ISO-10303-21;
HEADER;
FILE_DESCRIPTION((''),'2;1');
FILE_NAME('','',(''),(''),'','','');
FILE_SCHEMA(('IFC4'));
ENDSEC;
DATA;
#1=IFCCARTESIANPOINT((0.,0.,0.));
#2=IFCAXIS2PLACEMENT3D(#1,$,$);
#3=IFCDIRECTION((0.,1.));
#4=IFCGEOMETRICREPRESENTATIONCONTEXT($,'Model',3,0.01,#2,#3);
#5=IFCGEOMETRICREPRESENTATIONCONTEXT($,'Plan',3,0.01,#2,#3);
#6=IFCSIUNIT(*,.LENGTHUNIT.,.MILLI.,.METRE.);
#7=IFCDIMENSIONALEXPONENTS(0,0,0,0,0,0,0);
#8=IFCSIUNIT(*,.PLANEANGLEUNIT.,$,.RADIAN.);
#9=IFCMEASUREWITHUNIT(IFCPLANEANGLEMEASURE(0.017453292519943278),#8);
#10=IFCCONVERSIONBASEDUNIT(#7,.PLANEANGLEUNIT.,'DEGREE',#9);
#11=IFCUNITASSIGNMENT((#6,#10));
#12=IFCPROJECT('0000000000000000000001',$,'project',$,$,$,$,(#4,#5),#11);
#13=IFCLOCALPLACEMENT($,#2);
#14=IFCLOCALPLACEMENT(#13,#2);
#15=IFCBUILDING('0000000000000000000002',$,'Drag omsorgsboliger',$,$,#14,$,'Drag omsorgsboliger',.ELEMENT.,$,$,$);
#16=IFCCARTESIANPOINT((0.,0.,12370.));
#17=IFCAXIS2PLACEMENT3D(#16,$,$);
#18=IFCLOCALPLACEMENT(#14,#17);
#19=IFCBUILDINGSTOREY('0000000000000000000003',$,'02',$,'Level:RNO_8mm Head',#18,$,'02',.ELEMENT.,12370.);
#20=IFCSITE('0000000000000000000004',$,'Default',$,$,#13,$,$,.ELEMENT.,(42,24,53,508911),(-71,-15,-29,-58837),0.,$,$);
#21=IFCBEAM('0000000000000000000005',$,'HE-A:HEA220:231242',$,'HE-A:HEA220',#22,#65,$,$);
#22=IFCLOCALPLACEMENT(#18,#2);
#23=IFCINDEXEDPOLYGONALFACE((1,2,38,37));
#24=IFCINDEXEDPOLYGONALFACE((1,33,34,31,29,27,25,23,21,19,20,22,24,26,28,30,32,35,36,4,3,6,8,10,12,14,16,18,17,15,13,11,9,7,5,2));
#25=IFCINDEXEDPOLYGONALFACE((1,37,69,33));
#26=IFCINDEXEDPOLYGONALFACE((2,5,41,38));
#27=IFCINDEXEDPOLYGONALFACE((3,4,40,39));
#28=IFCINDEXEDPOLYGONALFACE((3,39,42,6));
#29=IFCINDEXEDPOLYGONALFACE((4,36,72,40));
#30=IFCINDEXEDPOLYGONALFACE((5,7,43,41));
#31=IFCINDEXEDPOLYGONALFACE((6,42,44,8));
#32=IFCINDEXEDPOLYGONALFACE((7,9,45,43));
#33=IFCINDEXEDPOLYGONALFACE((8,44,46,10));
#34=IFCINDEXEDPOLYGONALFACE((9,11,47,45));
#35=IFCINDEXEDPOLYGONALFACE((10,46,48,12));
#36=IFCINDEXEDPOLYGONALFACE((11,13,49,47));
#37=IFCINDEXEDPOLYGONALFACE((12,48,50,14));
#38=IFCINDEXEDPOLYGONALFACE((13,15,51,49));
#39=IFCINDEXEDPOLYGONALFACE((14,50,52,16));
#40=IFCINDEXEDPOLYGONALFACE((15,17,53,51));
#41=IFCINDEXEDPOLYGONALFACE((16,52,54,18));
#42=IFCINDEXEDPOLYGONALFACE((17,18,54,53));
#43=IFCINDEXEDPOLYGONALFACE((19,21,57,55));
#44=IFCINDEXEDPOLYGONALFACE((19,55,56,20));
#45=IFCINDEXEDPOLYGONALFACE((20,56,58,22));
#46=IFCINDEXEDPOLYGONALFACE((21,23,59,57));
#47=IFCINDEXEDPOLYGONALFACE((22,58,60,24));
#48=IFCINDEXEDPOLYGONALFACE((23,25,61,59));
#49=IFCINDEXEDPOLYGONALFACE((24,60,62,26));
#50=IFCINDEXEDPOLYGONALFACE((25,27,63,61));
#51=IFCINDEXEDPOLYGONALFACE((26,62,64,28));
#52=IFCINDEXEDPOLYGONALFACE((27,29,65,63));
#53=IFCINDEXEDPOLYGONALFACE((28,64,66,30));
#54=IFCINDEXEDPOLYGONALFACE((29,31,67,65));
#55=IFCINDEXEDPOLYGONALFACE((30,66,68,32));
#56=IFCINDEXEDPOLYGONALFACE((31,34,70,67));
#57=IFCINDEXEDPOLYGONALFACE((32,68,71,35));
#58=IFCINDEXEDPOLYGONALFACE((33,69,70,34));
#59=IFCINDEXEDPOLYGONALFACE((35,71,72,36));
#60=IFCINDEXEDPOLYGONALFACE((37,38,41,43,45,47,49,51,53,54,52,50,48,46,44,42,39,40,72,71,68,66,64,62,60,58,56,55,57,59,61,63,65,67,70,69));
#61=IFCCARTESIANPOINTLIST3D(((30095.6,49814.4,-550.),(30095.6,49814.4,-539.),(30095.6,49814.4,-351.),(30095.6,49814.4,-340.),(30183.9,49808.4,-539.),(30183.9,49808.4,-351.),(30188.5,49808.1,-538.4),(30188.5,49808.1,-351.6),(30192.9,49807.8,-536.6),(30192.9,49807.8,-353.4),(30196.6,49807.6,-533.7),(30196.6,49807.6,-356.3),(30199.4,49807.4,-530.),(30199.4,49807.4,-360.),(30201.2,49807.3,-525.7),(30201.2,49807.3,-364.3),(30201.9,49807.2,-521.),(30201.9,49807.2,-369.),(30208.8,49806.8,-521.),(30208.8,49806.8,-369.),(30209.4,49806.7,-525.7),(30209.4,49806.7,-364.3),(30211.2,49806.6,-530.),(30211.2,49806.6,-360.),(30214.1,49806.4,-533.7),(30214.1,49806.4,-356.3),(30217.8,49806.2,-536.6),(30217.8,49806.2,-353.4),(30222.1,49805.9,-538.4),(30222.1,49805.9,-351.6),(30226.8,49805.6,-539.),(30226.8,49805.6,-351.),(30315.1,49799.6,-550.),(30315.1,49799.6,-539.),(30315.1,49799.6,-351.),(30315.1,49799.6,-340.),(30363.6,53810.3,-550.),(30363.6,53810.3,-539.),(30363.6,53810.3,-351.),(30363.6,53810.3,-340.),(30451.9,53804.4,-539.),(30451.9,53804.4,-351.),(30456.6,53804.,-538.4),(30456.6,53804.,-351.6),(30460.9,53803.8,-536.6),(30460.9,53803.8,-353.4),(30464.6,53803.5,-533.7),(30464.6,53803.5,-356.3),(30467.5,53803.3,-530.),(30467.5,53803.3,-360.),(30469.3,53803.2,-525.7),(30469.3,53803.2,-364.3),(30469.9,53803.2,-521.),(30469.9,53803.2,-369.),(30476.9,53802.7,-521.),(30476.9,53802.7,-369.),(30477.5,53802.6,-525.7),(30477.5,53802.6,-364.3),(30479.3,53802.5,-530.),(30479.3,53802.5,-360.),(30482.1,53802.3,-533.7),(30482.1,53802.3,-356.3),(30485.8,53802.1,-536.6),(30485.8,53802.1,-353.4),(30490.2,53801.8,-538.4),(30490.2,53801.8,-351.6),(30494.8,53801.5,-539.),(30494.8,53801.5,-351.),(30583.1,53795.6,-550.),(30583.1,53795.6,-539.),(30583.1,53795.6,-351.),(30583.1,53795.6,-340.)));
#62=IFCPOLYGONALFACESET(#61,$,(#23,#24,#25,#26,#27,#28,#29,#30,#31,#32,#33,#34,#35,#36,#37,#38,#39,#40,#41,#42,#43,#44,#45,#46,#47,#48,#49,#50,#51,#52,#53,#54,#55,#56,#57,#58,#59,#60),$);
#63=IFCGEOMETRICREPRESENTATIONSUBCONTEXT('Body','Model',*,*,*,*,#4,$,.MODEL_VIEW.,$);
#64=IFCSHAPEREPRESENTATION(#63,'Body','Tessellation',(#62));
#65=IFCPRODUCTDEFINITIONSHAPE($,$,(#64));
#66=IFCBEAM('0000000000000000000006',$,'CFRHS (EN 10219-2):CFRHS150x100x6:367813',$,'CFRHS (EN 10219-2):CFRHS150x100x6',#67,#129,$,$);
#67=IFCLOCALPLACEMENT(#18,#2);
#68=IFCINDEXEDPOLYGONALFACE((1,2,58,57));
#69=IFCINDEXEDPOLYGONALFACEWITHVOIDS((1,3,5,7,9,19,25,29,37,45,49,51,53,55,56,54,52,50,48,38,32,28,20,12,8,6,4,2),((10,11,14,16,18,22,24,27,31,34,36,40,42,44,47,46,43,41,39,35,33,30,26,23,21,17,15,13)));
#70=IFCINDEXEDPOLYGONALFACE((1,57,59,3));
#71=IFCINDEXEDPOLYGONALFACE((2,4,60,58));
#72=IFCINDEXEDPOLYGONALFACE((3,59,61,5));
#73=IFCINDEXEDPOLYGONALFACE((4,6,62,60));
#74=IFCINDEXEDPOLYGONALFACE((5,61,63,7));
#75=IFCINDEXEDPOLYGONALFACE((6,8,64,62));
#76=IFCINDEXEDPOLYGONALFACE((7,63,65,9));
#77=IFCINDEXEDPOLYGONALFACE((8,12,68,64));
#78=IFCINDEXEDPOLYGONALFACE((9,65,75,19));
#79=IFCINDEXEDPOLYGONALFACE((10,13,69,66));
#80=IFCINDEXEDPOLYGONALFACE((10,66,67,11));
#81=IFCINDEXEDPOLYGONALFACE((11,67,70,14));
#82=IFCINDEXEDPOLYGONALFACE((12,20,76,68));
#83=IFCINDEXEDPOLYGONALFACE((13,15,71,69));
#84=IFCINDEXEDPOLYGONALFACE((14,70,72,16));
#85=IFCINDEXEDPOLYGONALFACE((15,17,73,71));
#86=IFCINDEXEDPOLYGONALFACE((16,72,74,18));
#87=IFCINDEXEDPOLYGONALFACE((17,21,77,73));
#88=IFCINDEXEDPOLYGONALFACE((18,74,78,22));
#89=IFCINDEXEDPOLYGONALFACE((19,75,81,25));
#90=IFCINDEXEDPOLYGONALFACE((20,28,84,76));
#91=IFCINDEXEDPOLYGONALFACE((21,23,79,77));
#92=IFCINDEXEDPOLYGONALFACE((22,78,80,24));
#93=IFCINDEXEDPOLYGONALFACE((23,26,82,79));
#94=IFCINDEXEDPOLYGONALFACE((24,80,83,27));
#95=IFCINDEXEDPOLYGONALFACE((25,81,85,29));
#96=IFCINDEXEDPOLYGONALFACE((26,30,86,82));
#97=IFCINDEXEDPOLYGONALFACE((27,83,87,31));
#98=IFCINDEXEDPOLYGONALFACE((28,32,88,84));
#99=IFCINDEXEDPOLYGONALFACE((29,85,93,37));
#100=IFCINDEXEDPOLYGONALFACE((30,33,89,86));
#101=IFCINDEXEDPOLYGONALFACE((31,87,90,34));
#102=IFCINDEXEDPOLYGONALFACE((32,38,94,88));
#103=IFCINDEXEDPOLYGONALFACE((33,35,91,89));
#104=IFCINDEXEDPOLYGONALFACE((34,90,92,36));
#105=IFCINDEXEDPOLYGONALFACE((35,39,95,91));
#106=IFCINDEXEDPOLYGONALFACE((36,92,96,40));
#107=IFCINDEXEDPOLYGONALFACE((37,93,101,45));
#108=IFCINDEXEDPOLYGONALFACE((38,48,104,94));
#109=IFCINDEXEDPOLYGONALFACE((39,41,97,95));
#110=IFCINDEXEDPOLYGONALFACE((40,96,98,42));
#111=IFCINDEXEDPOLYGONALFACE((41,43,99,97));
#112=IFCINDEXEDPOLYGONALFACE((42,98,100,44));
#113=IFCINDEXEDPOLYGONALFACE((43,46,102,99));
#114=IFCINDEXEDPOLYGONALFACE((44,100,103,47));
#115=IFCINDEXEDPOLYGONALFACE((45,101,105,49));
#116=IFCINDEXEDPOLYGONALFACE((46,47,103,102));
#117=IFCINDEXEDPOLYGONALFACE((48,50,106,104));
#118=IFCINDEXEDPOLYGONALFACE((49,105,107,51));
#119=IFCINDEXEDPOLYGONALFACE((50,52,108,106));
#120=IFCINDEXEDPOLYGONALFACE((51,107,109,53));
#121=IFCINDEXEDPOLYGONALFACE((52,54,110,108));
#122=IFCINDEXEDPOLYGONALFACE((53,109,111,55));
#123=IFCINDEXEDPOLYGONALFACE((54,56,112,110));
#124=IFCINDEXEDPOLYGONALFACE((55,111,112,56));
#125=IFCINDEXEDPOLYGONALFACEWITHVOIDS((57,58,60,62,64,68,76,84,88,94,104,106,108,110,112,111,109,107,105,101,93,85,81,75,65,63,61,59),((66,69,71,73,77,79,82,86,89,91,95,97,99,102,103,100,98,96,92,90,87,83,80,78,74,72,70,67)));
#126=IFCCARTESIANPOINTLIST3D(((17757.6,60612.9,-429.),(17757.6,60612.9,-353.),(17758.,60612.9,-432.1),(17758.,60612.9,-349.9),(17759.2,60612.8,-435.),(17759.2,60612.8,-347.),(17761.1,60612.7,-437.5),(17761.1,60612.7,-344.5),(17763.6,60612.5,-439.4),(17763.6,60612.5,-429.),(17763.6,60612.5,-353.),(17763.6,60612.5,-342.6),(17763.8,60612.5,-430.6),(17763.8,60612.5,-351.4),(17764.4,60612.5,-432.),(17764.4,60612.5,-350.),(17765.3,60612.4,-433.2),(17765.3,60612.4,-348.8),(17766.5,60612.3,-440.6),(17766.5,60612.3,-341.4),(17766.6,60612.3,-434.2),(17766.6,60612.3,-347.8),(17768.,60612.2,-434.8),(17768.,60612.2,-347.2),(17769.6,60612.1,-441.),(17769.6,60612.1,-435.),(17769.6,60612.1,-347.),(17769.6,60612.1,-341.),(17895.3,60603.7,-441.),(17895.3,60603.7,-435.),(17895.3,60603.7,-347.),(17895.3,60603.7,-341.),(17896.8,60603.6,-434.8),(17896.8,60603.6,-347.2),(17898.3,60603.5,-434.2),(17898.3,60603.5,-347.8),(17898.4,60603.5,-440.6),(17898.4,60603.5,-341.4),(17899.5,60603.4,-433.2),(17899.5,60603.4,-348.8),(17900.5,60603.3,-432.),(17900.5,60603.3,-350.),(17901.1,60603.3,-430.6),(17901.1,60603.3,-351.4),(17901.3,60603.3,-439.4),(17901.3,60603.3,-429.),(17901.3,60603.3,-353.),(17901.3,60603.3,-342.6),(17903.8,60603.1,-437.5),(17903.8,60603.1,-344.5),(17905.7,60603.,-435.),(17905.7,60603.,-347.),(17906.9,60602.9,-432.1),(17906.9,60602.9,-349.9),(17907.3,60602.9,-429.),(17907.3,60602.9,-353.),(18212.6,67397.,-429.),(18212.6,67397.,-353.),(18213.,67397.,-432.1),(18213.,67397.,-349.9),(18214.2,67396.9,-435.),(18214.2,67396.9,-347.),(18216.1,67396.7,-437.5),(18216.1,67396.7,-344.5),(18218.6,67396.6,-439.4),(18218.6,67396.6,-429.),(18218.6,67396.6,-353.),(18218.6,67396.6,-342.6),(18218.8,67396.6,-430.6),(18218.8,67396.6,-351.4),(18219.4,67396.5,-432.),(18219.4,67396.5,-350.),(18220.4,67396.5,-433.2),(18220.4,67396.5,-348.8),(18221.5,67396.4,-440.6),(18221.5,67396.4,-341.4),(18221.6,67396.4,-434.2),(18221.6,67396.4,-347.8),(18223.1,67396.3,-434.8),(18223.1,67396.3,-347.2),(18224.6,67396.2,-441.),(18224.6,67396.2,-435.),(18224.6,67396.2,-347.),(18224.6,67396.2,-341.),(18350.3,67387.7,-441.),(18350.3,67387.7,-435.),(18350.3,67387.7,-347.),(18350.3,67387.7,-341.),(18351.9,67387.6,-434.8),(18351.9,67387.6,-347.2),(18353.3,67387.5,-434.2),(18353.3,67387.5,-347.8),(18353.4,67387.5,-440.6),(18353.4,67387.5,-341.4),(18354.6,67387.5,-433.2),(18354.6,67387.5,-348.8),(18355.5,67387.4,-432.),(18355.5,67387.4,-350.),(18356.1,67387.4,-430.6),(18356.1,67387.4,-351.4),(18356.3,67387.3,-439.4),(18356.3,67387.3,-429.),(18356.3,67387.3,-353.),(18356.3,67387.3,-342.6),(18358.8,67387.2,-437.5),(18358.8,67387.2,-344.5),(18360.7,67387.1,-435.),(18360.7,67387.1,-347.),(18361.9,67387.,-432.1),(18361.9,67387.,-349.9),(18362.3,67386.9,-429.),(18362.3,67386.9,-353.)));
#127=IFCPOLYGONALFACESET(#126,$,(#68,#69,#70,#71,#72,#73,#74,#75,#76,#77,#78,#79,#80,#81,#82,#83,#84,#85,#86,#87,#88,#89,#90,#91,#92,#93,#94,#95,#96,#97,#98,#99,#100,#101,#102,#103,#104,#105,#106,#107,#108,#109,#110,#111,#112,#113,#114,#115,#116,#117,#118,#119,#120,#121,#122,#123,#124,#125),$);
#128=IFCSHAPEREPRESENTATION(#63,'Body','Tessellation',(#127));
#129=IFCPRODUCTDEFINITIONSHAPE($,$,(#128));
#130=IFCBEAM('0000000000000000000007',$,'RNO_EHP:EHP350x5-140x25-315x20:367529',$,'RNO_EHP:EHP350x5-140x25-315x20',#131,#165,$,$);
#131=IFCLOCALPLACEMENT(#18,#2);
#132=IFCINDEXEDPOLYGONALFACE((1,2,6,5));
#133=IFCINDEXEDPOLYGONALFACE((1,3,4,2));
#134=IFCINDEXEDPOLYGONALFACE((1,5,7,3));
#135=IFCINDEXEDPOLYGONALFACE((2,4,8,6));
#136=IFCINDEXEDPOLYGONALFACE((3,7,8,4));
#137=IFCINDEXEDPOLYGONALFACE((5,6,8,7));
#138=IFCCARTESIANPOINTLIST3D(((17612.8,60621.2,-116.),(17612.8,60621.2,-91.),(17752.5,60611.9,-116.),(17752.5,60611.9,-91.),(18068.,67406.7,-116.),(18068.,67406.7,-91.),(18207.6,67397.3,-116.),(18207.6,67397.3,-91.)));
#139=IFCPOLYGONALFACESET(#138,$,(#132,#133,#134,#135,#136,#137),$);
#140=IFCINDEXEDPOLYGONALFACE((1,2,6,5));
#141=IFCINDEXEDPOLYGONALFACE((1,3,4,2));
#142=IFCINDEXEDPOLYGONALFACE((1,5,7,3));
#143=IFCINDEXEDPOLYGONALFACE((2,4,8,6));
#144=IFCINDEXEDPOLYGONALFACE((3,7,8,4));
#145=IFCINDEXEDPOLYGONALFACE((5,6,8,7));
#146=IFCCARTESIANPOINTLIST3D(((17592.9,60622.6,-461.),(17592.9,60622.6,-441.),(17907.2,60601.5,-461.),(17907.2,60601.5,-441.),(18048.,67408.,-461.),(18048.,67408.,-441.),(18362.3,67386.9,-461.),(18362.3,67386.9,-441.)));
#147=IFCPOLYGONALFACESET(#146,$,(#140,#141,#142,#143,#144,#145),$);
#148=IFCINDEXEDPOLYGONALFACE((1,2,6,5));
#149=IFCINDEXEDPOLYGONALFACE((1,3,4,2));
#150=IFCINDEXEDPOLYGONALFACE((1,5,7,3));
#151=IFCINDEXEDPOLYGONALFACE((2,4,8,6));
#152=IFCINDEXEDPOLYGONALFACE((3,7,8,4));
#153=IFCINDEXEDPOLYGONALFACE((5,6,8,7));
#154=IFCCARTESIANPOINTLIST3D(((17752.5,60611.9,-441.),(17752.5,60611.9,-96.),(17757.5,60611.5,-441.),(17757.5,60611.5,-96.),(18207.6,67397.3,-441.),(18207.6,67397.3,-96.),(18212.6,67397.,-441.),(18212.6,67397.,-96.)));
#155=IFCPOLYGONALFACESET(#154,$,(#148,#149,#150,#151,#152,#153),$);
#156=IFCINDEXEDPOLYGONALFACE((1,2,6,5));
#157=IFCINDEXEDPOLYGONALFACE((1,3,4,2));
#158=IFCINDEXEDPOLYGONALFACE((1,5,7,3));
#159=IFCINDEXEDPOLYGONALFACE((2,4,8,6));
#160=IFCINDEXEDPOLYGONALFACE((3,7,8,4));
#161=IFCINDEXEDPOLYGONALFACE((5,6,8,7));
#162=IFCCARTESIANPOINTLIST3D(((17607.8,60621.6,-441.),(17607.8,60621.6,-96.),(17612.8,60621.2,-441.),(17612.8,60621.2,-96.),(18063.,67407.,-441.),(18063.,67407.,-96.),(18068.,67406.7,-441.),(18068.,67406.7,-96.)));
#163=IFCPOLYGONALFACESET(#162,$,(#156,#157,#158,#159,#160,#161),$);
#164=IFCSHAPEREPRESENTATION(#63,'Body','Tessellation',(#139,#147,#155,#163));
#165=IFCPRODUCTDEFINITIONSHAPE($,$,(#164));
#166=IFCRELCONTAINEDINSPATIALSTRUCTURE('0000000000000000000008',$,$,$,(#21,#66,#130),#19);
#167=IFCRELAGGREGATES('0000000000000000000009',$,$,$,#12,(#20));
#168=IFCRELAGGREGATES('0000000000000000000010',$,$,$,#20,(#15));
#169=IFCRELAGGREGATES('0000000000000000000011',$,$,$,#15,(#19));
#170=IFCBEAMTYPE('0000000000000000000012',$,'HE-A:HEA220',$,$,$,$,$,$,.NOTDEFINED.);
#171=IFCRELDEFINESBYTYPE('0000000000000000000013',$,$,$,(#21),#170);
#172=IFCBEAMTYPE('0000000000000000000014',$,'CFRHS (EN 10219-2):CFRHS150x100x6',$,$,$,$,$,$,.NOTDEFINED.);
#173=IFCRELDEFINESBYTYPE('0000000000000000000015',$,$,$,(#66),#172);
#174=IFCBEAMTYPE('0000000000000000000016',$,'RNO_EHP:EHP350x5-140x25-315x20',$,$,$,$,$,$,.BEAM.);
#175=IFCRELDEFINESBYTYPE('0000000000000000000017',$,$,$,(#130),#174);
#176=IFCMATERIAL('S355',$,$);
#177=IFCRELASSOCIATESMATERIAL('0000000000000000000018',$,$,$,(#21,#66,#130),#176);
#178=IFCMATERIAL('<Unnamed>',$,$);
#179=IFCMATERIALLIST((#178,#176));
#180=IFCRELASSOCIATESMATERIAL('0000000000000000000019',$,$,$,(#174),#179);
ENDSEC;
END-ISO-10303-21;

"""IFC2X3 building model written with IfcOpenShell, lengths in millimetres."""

from ifc_helpers import new_model, entity, si_unit, converted_unit, direction, frame, frame_2d, origin, place, context, subcontext, project, spatial, polyline, circle_curve, parameter, trimmed, segment, composite_curve, rectangle, i_section, outline, extrude, source, transform, mapped, material, material_list, type_object, type_shapes, element, save


model = new_model("IFC2X3")

# Units and contexts
model_context = context("Model", 3, precision=0.01, world=origin(), true_north=direction((0.0, 1.0)))
plan_context = context("Plan", 3, precision=0.01, world=origin(), true_north=direction((0.0, 1.0)))
body_context = subcontext(model_context, "Body", "Model", "MODEL_VIEW")
ifc_project = project(units=[si_unit("LENGTHUNIT", "METRE", prefix="MILLI"), converted_unit("PLANEANGLEUNIT", "DEGREE", entity("IfcPlaneAngleMeasure", 0.017453292519943278), si_unit("PLANEANGLEUNIT", "RADIAN"), dimensions=[0, 0, 0, 0, 0, 0, 0])], contexts=[model_context, plan_context])

# Site, building, storey
site_placement = place(None, origin())
site = spatial("IfcSite", under=ifc_project, at=site_placement, Name="Default", CompositionType="ELEMENT", RefLatitude=(42, 24, 53, 508911), RefLongitude=(-71, -15, -29, -58837), RefElevation=0.0)
building_placement = place(site_placement, origin())
building = spatial("IfcBuilding", under=site, at=building_placement, Name="Drag omsorgsboliger", LongName="Drag omsorgsboliger", CompositionType="ELEMENT")
storey_placement = place(building_placement, frame((0.0, 0.0, 12370.0)))
storey = spatial("IfcBuildingStorey", under=building, at=storey_placement, Name="02", ObjectType="Level:RNO_8mm Head", LongName="02", CompositionType="ELEMENT", Elevation=12370.0)

# Beams
ifc_material_1 = material(Name="S355")
beam_type_1 = type_object("IfcBeamType", Name="HE-A:HEA220", PredefinedType="NOTDEFINED")
beam_1_placement = place(storey_placement, frame((30205.3, 49806.9, -340.0), z_axis=(0.0, 0.0, 1.0), x_axis=(0.066923, 0.997758, 0.0)))
element("IfcBeam", 1, at=beam_1_placement, inside=storey, type_object=beam_type_1, material=ifc_material_1, Name="HE-A:HEA220:231242", ObjectType="HE-A:HEA220", context=body_context, shape_type="SweptSolid", body=[
    extrude(i_section(OverallWidth=220.0, OverallDepth=210.0, WebThickness=7.0, FlangeThickness=11.0, FilletRadius=18.0, at=frame_2d((0.0, 0.0), x_axis=(0.0, 1.0))), frame((0.0, 0.0, -105.0), z_axis=(1.0, 0.0, 0.0), x_axis=(0.0, 0.0, -1.0)), (0.0, 0.0, 1.0), 4004.9),
])
beam_type_2 = type_object("IfcBeamType", Name="CFRHS (EN 10219-2):CFRHS150x100x6", PredefinedType="NOTDEFINED")
beam_2_placement = place(storey_placement, frame((18362.3, 67386.9, -391.0), z_axis=(0.0, 0.0, 1.0), x_axis=(-0.066923, -0.997758, 0.0)))
element("IfcBeam", 2, at=beam_2_placement, inside=storey, type_object=beam_type_2, material=ifc_material_1, Name="CFRHS (EN 10219-2):CFRHS150x100x6:367813", ObjectType="CFRHS (EN 10219-2):CFRHS150x100x6", context=body_context, shape_type="SweptSolid", body=[
    extrude(outline(composite_curve([segment(trimmed(circle_curve(frame_2d((-38.0, -63.0), x_axis=(1.0, 0.0)), 12.0), [parameter(180.0)], [parameter(270.0)], True, "PARAMETER"), True, "CONTINUOUS"), segment(polyline([(-38.0, -75.0), (38.0, -75.0)]), True, "CONTINUOUS"), segment(trimmed(circle_curve(frame_2d((38.0, -63.0), x_axis=(1.0, 0.0)), 12.0), [parameter(270.0)], [parameter(360.0)], True, "PARAMETER"), True, "CONTINUOUS"), segment(polyline([(50.0, -63.0), (50.0, 63.0)]), True, "CONTINUOUS"), segment(trimmed(circle_curve(frame_2d((38.0, 63.0), x_axis=(1.0, 0.0)), 12.0), [parameter(360.0)], [parameter(90.0)], True, "PARAMETER"), True, "CONTINUOUS"), segment(polyline([(38.0, 75.0), (-38.0, 75.0)]), True, "CONTINUOUS"), segment(trimmed(circle_curve(frame_2d((-38.0, 63.0), x_axis=(1.0, 0.0)), 12.0), [parameter(90.0)], [parameter(180.0)], True, "PARAMETER"), True, "CONTINUOUS"), segment(polyline([(-50.0, 63.0), (-50.0, -63.0)]), True, "CONTINUOUS")], self_intersect=False), holes=[composite_curve([segment(polyline([(38.0, -69.0), (-38.0, -69.0)]), True, "CONTINUOUS"), segment(trimmed(circle_curve(frame_2d((-38.0, -63.0), x_axis=(1.0, 0.0)), 6.0), [parameter(180.0)], [parameter(270.0)], True, "PARAMETER"), False, "CONTINUOUS"), segment(polyline([(-44.0, -63.0), (-44.0, 63.0)]), True, "CONTINUOUS"), segment(trimmed(circle_curve(frame_2d((-38.0, 63.0), x_axis=(1.0, 0.0)), 6.0), [parameter(90.0)], [parameter(180.0)], True, "PARAMETER"), False, "CONTINUOUS"), segment(polyline([(-38.0, 69.0), (38.0, 69.0)]), True, "CONTINUOUS"), segment(trimmed(circle_curve(frame_2d((38.0, 63.0), x_axis=(1.0, 0.0)), 6.0), [parameter(0.0)], [parameter(90.0)], True, "PARAMETER"), False, "CONTINUOUS"), segment(polyline([(44.0, 63.0), (44.0, -63.0)]), True, "CONTINUOUS"), segment(trimmed(circle_curve(frame_2d((38.0, -63.0), x_axis=(1.0, 0.0)), 6.0), [parameter(270.0)], [parameter(0.0)], True, "PARAMETER"), False, "CONTINUOUS")], self_intersect=False)]), frame((0.0, -75.0, 0.0), z_axis=(1.0, 0.0, 0.0), x_axis=(0.0, 0.0, 1.0)), (0.0, 0.0, 1.0), 6799.3),
])
ifc_material_2 = material(Name="<Unnamed>")
ifc_material_list = material_list([ifc_material_2, ifc_material_1])
beam_type_3 = type_object("IfcBeamType", Name="RNO_EHP:EHP350x5-140x25-315x20", PredefinedType="BEAM", material=ifc_material_list)
shared_shape_1 = source(origin(), body_context, "Body", "SweptSolid", [
    extrude(rectangle(XDim=25.0, YDim=140.0, at=frame_2d((0.0, 0.0), x_axis=(1.0, 0.0))), frame((-3399.0, 0.0, 162.5), z_axis=(1.0, 0.0, 0.0), x_axis=(0.0, 0.0, -1.0)), (0.0, 0.0, 1.0), 6800.7),
    extrude(rectangle(XDim=20.0, YDim=315.0, at=frame_2d((0.0, 0.0), x_axis=(1.0, 0.0))), frame((-3399.0, 67.5, -185.0), z_axis=(1.0, 0.0, 0.0), x_axis=(0.0, 0.0, -1.0)), (0.0, 0.0, 1.0), 6800.7),
    extrude(rectangle(XDim=345.0, YDim=5.0, at=frame_2d((0.0, 0.0), x_axis=(1.0, 0.0))), frame((-3399.0, 72.5, -2.5), z_axis=(1.0, 0.0, 0.0), x_axis=(0.0, 0.0, -1.0)), (0.0, 0.0, 1.0), 6800.7),
    extrude(rectangle(XDim=345.0, YDim=5.0, at=frame_2d((0.0, 0.0), x_axis=(1.0, 0.0))), frame((-3399.0, -72.5, -2.5), z_axis=(1.0, 0.0, 0.0), x_axis=(0.0, 0.0, -1.0)), (0.0, 0.0, 1.0), 6800.7),
])
type_shapes(beam_type_3, [shared_shape_1])
beam_3_placement = place(storey_placement, frame((17910.3, 64010.6, -266.0), z_axis=(0.0, 0.0, 1.0), x_axis=(-0.066923, -0.997758, 0.0)))
element("IfcBeam", 3, at=beam_3_placement, inside=storey, type_object=beam_type_3, material=ifc_material_1, Name="RNO_EHP:EHP350x5-140x25-315x20:367529", ObjectType="RNO_EHP:EHP350x5-140x25-315x20", context=body_context, shape_type="MappedRepresentation", body=[
    mapped(shared_shape_1, transform((0.0, 0.0, 0.0), scale=1.0)),
])

save(model, "model.ifc")
